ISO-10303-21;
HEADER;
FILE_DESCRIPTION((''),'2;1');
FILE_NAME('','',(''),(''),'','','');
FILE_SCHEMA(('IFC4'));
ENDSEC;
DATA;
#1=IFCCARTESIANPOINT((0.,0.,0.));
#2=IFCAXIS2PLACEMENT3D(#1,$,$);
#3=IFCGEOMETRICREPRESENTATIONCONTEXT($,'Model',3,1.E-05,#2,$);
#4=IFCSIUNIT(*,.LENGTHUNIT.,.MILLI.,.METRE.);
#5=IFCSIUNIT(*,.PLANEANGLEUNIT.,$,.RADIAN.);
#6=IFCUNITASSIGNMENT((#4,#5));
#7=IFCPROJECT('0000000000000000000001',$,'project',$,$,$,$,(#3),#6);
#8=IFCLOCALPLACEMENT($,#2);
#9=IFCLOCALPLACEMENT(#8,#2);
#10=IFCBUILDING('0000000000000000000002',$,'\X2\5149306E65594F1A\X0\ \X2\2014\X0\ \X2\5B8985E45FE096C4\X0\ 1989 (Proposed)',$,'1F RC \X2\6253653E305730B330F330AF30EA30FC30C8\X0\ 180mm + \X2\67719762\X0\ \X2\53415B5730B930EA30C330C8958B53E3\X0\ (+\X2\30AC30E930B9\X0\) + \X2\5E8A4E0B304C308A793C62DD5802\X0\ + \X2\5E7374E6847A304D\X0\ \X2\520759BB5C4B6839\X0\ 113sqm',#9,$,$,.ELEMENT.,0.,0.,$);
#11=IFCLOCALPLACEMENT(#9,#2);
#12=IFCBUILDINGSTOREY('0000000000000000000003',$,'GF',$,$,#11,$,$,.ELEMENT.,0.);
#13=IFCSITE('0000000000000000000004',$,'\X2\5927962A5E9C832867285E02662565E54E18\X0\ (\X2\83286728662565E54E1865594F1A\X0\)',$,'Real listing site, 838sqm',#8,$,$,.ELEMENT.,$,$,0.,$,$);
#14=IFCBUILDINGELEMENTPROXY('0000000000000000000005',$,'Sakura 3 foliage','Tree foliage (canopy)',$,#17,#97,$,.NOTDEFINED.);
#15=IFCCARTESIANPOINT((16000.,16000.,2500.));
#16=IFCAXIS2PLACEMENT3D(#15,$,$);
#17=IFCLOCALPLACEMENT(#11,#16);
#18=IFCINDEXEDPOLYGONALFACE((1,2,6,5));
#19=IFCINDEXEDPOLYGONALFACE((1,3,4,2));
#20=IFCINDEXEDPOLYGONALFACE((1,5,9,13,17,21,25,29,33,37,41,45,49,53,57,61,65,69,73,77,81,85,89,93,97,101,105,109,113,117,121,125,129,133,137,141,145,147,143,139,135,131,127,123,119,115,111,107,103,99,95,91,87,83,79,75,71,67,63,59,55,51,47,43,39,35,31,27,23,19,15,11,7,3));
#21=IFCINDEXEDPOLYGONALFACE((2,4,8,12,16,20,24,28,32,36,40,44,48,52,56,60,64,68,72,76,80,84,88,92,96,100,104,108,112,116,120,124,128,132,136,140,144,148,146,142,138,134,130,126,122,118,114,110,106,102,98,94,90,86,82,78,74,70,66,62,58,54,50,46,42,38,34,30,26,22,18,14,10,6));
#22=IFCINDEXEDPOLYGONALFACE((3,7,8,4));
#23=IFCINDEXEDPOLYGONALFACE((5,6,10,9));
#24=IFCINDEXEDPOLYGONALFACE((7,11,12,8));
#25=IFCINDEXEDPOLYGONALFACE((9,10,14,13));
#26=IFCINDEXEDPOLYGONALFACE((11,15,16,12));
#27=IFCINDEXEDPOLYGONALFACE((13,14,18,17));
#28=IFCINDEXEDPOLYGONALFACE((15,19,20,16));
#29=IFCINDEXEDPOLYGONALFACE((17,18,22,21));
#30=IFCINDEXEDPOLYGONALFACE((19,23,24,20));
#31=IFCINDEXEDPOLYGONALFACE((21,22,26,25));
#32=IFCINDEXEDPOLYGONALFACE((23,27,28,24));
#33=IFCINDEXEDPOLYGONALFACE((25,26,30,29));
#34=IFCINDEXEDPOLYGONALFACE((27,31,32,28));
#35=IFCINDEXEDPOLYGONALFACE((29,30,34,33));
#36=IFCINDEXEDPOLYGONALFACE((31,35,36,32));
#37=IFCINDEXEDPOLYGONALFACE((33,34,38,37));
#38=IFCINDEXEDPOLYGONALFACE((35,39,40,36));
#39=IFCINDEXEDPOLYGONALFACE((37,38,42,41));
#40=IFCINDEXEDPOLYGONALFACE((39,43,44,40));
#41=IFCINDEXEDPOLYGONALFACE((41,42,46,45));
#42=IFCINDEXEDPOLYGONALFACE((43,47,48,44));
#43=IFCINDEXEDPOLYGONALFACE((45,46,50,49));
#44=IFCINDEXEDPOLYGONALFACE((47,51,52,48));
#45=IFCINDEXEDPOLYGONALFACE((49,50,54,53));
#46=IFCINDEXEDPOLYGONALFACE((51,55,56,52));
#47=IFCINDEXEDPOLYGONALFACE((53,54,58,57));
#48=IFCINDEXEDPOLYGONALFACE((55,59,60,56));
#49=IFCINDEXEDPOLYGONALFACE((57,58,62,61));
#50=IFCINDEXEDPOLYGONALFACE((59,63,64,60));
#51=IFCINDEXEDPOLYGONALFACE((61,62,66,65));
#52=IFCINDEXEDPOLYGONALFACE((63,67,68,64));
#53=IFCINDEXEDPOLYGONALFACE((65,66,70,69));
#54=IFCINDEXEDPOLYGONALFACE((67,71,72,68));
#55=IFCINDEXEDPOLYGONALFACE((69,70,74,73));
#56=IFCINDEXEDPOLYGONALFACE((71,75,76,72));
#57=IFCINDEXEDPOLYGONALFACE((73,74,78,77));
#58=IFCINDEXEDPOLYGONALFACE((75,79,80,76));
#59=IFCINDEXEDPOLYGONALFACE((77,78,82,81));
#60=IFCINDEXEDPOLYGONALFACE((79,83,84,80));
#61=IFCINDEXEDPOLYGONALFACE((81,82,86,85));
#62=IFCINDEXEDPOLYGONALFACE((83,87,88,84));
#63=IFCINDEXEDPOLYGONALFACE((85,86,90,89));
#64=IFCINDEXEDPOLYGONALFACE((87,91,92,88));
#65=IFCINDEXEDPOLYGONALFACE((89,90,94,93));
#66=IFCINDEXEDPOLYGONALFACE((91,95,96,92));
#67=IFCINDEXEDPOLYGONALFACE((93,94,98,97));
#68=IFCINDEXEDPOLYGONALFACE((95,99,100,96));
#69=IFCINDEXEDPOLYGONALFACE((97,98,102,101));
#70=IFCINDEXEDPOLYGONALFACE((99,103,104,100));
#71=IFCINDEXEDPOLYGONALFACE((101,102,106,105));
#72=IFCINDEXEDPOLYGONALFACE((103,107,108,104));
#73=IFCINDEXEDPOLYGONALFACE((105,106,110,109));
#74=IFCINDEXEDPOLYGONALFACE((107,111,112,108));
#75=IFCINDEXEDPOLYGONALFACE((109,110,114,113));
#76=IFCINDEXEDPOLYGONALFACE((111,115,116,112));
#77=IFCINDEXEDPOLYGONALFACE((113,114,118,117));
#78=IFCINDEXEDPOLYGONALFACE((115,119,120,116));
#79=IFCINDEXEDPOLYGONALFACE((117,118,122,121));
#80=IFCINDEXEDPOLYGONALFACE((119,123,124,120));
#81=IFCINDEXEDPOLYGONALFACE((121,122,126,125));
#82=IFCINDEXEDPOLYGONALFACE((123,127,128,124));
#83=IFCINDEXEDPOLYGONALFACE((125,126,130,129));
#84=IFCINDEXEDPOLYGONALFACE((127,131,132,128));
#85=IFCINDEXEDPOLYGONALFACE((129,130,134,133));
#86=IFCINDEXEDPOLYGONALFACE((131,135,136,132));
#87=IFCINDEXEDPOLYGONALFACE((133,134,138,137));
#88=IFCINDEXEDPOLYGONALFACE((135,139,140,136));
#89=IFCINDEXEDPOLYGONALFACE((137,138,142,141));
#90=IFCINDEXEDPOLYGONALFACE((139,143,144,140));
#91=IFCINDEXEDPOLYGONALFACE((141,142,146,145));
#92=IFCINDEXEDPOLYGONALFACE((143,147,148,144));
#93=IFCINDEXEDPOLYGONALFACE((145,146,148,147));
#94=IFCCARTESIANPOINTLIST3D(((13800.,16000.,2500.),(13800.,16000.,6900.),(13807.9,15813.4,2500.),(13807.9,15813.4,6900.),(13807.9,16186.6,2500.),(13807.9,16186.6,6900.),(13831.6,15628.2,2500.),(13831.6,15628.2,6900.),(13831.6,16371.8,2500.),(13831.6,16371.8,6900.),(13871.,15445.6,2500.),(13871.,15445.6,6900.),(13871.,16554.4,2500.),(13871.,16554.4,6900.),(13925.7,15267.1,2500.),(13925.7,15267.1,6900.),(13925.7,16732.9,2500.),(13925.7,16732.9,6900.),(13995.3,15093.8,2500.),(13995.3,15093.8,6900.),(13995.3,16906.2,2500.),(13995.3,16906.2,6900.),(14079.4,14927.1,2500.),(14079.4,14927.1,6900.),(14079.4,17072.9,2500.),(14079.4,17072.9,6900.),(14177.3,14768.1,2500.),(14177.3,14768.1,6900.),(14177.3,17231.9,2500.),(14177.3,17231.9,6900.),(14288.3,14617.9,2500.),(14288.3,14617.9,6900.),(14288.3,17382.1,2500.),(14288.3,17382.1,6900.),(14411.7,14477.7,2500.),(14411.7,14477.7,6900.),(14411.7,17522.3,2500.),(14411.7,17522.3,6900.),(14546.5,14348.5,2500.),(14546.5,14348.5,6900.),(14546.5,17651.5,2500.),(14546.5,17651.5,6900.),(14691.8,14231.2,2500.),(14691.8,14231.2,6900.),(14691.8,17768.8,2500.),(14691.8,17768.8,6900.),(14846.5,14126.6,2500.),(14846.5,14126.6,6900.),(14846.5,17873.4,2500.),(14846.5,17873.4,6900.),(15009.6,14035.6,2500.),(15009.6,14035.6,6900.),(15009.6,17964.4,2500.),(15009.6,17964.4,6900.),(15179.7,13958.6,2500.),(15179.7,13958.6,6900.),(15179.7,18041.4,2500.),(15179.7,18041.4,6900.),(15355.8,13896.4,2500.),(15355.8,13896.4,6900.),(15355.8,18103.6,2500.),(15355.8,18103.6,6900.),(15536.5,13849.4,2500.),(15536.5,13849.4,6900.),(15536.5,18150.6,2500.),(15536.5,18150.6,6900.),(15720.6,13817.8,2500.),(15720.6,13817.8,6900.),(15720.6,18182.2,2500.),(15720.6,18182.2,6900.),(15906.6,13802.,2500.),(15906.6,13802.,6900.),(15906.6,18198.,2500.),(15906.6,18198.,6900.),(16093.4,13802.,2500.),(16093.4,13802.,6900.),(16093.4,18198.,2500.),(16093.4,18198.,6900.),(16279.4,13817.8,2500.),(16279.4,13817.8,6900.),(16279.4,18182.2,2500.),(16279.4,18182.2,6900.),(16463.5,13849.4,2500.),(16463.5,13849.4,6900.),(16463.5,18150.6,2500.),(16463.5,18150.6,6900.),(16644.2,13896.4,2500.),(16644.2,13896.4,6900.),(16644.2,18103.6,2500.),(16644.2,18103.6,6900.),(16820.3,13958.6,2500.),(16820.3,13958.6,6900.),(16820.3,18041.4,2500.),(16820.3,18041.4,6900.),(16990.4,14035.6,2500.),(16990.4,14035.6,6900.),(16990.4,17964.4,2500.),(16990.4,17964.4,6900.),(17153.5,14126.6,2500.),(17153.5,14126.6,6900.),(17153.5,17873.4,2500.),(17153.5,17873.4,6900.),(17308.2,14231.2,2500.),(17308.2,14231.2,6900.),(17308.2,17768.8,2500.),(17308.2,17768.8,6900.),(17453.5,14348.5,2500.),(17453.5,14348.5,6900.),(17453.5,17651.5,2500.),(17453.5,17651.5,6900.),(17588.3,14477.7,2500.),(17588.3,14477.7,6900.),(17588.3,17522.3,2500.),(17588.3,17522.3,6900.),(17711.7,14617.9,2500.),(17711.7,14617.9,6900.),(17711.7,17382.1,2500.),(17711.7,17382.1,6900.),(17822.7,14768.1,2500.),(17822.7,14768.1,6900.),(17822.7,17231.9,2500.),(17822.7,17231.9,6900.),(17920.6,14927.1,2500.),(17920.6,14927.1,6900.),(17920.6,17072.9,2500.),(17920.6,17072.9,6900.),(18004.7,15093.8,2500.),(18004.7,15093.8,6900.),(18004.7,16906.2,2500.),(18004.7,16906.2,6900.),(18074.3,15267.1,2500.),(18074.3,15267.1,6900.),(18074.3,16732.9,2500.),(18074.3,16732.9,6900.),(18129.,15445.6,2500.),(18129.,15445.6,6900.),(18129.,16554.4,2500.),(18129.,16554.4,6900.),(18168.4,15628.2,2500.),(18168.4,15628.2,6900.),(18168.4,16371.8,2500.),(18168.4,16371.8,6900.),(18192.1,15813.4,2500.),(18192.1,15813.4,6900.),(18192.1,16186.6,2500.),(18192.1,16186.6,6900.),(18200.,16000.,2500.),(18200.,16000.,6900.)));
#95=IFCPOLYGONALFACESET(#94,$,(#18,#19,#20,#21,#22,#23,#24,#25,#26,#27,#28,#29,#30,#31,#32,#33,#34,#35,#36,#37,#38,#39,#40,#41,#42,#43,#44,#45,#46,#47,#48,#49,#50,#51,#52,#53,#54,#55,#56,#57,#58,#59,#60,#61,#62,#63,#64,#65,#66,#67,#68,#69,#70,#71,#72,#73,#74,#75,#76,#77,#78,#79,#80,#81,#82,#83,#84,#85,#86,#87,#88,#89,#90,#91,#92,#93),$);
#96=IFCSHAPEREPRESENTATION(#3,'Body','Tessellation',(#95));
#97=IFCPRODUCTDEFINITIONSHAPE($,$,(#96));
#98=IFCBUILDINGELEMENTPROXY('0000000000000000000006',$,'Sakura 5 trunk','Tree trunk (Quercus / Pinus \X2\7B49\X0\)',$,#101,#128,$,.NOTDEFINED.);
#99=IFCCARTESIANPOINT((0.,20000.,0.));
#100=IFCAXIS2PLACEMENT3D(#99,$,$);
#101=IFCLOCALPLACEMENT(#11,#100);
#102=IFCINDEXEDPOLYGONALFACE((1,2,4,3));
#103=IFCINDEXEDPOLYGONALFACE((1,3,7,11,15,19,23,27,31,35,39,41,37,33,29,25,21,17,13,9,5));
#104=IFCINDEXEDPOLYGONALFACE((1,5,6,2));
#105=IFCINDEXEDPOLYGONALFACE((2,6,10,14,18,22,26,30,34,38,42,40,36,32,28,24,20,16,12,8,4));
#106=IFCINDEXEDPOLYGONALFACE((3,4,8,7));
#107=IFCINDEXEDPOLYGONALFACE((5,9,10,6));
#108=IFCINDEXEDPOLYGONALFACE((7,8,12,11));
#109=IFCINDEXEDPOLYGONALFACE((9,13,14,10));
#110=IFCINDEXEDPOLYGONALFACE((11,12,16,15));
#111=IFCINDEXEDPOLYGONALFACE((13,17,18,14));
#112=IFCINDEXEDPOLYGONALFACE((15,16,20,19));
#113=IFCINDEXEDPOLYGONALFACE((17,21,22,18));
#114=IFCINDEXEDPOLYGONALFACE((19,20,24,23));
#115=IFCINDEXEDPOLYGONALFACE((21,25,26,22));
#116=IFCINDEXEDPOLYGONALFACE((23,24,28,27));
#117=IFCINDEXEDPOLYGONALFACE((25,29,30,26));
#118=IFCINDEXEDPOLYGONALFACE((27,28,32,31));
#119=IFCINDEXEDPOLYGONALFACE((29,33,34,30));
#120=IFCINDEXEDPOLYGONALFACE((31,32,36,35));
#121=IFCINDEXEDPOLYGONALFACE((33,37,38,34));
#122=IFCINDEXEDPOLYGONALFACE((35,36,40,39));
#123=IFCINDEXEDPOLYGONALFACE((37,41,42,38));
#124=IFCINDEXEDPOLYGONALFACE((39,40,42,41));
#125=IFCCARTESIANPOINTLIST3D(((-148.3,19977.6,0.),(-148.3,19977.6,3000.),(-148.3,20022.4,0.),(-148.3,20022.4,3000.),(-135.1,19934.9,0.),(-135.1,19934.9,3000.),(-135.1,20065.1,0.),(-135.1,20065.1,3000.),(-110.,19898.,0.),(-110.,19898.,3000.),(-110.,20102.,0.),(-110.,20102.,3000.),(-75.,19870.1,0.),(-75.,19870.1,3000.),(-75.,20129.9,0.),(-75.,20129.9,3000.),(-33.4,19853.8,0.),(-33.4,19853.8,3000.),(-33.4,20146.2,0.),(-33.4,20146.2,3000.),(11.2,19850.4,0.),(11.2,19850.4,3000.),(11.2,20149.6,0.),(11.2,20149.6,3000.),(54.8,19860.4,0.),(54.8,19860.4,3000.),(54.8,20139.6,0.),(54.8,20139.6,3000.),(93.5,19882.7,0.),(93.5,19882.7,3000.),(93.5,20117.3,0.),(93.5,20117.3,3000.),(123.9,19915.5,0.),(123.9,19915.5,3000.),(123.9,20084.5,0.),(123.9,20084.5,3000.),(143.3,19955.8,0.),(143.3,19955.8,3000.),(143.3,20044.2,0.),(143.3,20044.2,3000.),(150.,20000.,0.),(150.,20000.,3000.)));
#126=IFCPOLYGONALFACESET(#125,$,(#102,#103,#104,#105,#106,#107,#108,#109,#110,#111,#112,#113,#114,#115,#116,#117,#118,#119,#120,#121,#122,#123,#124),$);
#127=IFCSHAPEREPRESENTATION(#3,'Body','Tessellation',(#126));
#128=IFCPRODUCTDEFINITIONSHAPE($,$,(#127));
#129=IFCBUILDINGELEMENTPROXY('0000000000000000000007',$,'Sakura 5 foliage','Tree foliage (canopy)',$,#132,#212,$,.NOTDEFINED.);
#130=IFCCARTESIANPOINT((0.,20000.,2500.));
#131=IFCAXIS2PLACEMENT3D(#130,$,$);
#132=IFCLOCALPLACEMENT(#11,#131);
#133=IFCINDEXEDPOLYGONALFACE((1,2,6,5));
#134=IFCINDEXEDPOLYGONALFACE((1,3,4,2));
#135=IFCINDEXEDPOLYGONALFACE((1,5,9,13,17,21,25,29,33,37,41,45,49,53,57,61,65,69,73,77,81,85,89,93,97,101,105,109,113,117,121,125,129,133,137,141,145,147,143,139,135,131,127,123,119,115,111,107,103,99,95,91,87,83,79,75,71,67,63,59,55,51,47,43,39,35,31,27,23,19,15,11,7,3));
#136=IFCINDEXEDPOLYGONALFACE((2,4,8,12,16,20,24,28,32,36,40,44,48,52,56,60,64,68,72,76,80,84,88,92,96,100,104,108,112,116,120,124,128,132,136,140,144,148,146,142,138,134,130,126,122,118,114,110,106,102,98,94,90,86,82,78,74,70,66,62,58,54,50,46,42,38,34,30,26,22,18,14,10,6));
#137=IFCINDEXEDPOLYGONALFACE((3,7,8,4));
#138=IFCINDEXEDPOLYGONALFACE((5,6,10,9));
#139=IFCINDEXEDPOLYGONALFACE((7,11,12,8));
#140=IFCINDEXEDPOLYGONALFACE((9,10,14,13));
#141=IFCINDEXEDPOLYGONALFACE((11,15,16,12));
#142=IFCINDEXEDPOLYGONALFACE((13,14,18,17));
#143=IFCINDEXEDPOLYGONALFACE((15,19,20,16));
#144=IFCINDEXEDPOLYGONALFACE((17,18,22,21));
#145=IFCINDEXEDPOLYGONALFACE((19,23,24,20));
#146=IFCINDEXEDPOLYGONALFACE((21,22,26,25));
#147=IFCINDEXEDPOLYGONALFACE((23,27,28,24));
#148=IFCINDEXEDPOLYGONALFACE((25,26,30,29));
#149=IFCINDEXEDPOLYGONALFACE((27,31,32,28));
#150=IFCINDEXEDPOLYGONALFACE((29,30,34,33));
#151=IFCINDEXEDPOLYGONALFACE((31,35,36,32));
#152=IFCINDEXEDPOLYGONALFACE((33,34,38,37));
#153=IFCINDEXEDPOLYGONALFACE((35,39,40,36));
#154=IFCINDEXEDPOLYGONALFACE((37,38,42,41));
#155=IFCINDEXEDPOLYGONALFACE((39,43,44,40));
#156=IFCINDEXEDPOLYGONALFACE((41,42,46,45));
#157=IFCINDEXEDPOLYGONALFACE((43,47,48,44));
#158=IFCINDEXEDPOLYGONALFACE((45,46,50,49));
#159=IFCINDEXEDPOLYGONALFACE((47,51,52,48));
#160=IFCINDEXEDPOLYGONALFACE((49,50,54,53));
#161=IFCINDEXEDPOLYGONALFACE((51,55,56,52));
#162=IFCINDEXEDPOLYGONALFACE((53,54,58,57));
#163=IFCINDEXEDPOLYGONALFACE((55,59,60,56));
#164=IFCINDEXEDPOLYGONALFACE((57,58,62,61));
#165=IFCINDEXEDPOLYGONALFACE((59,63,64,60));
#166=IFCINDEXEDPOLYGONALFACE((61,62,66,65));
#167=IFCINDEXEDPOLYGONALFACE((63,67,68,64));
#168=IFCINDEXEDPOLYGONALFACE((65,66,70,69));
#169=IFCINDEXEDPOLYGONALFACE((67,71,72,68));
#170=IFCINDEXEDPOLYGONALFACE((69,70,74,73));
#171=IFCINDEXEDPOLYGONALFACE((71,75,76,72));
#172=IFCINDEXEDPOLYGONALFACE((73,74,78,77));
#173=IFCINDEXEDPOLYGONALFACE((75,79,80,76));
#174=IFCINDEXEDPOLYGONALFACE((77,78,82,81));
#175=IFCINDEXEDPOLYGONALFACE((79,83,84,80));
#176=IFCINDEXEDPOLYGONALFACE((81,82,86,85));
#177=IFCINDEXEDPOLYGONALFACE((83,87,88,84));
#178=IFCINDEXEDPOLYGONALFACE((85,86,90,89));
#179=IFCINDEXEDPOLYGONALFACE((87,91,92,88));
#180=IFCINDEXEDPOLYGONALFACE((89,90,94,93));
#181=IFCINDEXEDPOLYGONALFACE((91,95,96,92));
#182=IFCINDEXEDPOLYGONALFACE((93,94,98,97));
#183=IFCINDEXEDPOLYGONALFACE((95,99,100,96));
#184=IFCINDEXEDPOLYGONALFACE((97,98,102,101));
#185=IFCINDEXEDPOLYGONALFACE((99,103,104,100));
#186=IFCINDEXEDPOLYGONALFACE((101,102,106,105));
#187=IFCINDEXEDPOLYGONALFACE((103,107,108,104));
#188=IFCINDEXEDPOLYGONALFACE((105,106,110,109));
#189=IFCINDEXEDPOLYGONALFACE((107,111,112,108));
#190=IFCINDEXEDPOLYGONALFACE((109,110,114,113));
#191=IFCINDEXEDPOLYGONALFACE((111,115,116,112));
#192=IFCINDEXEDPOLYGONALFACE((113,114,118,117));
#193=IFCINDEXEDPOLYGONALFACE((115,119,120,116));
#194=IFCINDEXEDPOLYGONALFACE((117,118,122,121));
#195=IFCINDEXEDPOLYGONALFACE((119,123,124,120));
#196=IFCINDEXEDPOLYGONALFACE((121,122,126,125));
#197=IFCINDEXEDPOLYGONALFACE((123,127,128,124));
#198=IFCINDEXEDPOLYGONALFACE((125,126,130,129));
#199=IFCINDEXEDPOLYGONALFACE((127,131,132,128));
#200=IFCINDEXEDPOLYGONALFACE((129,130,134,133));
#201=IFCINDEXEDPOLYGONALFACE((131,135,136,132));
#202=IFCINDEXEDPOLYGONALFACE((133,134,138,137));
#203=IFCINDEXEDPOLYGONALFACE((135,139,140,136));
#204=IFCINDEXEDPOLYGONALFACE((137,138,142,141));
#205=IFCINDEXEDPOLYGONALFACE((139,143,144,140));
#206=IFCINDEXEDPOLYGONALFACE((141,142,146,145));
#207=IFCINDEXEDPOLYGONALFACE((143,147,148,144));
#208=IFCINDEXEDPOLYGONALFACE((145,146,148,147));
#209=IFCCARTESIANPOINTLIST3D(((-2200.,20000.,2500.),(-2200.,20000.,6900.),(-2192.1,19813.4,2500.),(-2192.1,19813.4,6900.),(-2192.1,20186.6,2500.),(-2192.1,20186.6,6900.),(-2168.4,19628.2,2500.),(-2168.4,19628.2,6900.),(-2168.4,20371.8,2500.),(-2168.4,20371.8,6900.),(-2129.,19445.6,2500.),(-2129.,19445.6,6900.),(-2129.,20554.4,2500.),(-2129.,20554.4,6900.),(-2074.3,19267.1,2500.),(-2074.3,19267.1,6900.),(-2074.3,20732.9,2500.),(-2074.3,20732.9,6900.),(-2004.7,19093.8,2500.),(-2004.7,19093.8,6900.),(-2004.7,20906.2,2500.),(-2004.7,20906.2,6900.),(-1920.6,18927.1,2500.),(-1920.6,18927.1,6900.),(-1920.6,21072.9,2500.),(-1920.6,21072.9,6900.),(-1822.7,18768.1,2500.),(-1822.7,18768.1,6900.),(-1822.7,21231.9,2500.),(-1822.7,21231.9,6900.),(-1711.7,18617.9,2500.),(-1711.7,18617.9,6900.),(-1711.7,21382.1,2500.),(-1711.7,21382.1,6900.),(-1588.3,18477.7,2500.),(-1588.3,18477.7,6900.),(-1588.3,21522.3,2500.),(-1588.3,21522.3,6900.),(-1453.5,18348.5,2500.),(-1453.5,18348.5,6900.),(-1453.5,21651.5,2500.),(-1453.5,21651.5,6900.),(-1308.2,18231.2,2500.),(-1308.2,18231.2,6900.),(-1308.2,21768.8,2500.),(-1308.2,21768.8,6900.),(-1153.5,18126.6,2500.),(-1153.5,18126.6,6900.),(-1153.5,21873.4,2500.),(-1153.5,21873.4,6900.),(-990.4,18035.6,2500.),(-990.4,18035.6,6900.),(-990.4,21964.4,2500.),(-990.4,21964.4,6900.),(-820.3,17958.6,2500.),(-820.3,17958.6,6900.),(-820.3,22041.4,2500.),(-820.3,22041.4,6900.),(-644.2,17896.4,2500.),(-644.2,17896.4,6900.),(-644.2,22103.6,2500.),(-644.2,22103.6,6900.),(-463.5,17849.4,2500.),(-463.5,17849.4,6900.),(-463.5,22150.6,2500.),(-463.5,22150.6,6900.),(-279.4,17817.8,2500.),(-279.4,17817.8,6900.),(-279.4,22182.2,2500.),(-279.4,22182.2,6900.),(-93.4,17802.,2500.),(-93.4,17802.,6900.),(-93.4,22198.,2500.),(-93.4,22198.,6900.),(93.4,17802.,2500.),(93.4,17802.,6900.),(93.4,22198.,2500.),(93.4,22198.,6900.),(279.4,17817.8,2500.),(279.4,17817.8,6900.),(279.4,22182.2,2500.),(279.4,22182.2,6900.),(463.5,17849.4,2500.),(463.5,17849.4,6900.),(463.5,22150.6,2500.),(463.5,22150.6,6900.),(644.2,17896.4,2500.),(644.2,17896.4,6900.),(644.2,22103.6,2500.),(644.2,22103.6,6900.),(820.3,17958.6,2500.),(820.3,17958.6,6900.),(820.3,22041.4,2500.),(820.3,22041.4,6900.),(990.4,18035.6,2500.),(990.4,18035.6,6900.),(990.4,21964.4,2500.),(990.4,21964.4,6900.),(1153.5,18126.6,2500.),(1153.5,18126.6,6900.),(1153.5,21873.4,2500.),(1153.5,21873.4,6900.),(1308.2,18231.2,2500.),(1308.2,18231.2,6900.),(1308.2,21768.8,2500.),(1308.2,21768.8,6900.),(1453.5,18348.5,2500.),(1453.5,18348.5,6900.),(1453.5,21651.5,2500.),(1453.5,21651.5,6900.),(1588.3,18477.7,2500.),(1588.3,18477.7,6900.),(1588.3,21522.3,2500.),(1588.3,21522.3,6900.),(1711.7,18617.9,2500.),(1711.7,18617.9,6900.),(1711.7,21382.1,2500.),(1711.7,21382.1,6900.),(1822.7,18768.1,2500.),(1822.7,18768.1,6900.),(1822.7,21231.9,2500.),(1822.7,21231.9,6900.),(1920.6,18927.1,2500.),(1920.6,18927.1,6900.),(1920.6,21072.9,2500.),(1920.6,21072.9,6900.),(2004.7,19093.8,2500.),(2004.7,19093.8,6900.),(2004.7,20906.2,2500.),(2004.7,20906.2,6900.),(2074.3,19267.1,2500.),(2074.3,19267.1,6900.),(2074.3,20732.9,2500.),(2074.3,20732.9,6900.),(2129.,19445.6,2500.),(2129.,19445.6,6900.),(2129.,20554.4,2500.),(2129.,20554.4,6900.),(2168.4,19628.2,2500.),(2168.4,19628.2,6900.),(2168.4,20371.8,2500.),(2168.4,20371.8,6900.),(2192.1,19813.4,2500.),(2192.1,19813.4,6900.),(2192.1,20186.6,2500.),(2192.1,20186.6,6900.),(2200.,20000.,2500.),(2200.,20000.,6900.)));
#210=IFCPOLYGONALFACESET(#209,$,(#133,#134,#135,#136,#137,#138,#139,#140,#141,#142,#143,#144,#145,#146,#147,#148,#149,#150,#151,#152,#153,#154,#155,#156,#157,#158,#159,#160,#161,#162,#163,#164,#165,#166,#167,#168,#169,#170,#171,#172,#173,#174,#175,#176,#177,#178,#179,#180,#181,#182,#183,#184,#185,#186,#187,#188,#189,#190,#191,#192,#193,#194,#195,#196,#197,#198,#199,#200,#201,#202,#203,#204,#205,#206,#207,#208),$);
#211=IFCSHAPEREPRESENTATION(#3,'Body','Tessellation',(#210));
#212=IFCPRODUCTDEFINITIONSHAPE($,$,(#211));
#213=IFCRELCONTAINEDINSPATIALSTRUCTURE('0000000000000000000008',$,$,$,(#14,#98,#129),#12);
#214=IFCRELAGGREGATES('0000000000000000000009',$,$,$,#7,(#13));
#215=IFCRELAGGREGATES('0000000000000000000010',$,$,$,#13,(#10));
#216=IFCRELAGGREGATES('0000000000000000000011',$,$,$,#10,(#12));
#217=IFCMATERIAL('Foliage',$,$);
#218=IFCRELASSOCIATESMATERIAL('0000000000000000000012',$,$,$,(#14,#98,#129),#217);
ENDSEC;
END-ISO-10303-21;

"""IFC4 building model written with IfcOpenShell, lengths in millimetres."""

from ifc_helpers import new_model, si_unit, frame, origin, origin_2d, place, context, project, spatial, circle, extrude, material, element, save


model = new_model("IFC4")

# Units and contexts
model_context = context("Model", 3, precision=1e-05, world=origin())
ifc_project = project(units=[si_unit("LENGTHUNIT", "METRE", prefix="MILLI"), si_unit("PLANEANGLEUNIT", "RADIAN")], contexts=[model_context])

# Site, building, storey
site_placement = place(None, origin())
site = spatial("IfcSite", under=ifc_project, at=site_placement, Name="大阪府茨木市春日丘 (茨木春日丘教会)", ObjectType="Real listing site, 838sqm", CompositionType="ELEMENT", RefElevation=0.0)
building_placement = place(site_placement, origin())
building = spatial("IfcBuilding", under=site, at=building_placement, Name="光の教会 — 安藤忠雄 1989 (Proposed)", ObjectType="1F RC 打放しコンクリート 180mm + 東面 十字スリット開口 (+ガラス) + 床下がり礼拝堂 + 平瓦葺き 切妻屋根 113sqm", CompositionType="ELEMENT", ElevationOfRefHeight=0.0, ElevationOfTerrain=0.0)
storey_placement = place(building_placement, origin())
storey = spatial("IfcBuildingStorey", under=building, at=storey_placement, Name="GF", CompositionType="ELEMENT", Elevation=0.0)

# Building element proxies
ifc_material_1 = material(Name="Foliage")
proxy_1_placement = place(storey_placement, frame((16000.0, 16000.0, 2500.0)))
element("IfcBuildingElementProxy", 1, at=proxy_1_placement, inside=storey, material=ifc_material_1, Name="Sakura 3 foliage", Description="Tree foliage (canopy)", PredefinedType="NOTDEFINED", context=model_context, shape_type="SweptSolid", body=[
    extrude(circle(Radius=2200.0, at=origin_2d()), frame((16000.0, 16000.0, 2500.0)), (0.0, 0.0, 1.0), 4400.0),
])
proxy_2_placement = place(storey_placement, frame((0.0, 20000.0, 0.0)))
element("IfcBuildingElementProxy", 2, at=proxy_2_placement, inside=storey, material=ifc_material_1, Name="Sakura 5 trunk", Description="Tree trunk (Quercus / Pinus 等)", PredefinedType="NOTDEFINED", context=model_context, shape_type="SweptSolid", body=[
    extrude(circle(Radius=150.0, at=origin_2d()), frame((0.0, 20000.0, 0.0)), (0.0, 0.0, 1.0), 3000.0),
])
proxy_3_placement = place(storey_placement, frame((0.0, 20000.0, 2500.0)))
element("IfcBuildingElementProxy", 3, at=proxy_3_placement, inside=storey, material=ifc_material_1, Name="Sakura 5 foliage", Description="Tree foliage (canopy)", PredefinedType="NOTDEFINED", context=model_context, shape_type="SweptSolid", body=[
    extrude(circle(Radius=2200.0, at=origin_2d()), frame((0.0, 20000.0, 2500.0)), (0.0, 0.0, 1.0), 4400.0),
])

save(model, "model.ifc")
